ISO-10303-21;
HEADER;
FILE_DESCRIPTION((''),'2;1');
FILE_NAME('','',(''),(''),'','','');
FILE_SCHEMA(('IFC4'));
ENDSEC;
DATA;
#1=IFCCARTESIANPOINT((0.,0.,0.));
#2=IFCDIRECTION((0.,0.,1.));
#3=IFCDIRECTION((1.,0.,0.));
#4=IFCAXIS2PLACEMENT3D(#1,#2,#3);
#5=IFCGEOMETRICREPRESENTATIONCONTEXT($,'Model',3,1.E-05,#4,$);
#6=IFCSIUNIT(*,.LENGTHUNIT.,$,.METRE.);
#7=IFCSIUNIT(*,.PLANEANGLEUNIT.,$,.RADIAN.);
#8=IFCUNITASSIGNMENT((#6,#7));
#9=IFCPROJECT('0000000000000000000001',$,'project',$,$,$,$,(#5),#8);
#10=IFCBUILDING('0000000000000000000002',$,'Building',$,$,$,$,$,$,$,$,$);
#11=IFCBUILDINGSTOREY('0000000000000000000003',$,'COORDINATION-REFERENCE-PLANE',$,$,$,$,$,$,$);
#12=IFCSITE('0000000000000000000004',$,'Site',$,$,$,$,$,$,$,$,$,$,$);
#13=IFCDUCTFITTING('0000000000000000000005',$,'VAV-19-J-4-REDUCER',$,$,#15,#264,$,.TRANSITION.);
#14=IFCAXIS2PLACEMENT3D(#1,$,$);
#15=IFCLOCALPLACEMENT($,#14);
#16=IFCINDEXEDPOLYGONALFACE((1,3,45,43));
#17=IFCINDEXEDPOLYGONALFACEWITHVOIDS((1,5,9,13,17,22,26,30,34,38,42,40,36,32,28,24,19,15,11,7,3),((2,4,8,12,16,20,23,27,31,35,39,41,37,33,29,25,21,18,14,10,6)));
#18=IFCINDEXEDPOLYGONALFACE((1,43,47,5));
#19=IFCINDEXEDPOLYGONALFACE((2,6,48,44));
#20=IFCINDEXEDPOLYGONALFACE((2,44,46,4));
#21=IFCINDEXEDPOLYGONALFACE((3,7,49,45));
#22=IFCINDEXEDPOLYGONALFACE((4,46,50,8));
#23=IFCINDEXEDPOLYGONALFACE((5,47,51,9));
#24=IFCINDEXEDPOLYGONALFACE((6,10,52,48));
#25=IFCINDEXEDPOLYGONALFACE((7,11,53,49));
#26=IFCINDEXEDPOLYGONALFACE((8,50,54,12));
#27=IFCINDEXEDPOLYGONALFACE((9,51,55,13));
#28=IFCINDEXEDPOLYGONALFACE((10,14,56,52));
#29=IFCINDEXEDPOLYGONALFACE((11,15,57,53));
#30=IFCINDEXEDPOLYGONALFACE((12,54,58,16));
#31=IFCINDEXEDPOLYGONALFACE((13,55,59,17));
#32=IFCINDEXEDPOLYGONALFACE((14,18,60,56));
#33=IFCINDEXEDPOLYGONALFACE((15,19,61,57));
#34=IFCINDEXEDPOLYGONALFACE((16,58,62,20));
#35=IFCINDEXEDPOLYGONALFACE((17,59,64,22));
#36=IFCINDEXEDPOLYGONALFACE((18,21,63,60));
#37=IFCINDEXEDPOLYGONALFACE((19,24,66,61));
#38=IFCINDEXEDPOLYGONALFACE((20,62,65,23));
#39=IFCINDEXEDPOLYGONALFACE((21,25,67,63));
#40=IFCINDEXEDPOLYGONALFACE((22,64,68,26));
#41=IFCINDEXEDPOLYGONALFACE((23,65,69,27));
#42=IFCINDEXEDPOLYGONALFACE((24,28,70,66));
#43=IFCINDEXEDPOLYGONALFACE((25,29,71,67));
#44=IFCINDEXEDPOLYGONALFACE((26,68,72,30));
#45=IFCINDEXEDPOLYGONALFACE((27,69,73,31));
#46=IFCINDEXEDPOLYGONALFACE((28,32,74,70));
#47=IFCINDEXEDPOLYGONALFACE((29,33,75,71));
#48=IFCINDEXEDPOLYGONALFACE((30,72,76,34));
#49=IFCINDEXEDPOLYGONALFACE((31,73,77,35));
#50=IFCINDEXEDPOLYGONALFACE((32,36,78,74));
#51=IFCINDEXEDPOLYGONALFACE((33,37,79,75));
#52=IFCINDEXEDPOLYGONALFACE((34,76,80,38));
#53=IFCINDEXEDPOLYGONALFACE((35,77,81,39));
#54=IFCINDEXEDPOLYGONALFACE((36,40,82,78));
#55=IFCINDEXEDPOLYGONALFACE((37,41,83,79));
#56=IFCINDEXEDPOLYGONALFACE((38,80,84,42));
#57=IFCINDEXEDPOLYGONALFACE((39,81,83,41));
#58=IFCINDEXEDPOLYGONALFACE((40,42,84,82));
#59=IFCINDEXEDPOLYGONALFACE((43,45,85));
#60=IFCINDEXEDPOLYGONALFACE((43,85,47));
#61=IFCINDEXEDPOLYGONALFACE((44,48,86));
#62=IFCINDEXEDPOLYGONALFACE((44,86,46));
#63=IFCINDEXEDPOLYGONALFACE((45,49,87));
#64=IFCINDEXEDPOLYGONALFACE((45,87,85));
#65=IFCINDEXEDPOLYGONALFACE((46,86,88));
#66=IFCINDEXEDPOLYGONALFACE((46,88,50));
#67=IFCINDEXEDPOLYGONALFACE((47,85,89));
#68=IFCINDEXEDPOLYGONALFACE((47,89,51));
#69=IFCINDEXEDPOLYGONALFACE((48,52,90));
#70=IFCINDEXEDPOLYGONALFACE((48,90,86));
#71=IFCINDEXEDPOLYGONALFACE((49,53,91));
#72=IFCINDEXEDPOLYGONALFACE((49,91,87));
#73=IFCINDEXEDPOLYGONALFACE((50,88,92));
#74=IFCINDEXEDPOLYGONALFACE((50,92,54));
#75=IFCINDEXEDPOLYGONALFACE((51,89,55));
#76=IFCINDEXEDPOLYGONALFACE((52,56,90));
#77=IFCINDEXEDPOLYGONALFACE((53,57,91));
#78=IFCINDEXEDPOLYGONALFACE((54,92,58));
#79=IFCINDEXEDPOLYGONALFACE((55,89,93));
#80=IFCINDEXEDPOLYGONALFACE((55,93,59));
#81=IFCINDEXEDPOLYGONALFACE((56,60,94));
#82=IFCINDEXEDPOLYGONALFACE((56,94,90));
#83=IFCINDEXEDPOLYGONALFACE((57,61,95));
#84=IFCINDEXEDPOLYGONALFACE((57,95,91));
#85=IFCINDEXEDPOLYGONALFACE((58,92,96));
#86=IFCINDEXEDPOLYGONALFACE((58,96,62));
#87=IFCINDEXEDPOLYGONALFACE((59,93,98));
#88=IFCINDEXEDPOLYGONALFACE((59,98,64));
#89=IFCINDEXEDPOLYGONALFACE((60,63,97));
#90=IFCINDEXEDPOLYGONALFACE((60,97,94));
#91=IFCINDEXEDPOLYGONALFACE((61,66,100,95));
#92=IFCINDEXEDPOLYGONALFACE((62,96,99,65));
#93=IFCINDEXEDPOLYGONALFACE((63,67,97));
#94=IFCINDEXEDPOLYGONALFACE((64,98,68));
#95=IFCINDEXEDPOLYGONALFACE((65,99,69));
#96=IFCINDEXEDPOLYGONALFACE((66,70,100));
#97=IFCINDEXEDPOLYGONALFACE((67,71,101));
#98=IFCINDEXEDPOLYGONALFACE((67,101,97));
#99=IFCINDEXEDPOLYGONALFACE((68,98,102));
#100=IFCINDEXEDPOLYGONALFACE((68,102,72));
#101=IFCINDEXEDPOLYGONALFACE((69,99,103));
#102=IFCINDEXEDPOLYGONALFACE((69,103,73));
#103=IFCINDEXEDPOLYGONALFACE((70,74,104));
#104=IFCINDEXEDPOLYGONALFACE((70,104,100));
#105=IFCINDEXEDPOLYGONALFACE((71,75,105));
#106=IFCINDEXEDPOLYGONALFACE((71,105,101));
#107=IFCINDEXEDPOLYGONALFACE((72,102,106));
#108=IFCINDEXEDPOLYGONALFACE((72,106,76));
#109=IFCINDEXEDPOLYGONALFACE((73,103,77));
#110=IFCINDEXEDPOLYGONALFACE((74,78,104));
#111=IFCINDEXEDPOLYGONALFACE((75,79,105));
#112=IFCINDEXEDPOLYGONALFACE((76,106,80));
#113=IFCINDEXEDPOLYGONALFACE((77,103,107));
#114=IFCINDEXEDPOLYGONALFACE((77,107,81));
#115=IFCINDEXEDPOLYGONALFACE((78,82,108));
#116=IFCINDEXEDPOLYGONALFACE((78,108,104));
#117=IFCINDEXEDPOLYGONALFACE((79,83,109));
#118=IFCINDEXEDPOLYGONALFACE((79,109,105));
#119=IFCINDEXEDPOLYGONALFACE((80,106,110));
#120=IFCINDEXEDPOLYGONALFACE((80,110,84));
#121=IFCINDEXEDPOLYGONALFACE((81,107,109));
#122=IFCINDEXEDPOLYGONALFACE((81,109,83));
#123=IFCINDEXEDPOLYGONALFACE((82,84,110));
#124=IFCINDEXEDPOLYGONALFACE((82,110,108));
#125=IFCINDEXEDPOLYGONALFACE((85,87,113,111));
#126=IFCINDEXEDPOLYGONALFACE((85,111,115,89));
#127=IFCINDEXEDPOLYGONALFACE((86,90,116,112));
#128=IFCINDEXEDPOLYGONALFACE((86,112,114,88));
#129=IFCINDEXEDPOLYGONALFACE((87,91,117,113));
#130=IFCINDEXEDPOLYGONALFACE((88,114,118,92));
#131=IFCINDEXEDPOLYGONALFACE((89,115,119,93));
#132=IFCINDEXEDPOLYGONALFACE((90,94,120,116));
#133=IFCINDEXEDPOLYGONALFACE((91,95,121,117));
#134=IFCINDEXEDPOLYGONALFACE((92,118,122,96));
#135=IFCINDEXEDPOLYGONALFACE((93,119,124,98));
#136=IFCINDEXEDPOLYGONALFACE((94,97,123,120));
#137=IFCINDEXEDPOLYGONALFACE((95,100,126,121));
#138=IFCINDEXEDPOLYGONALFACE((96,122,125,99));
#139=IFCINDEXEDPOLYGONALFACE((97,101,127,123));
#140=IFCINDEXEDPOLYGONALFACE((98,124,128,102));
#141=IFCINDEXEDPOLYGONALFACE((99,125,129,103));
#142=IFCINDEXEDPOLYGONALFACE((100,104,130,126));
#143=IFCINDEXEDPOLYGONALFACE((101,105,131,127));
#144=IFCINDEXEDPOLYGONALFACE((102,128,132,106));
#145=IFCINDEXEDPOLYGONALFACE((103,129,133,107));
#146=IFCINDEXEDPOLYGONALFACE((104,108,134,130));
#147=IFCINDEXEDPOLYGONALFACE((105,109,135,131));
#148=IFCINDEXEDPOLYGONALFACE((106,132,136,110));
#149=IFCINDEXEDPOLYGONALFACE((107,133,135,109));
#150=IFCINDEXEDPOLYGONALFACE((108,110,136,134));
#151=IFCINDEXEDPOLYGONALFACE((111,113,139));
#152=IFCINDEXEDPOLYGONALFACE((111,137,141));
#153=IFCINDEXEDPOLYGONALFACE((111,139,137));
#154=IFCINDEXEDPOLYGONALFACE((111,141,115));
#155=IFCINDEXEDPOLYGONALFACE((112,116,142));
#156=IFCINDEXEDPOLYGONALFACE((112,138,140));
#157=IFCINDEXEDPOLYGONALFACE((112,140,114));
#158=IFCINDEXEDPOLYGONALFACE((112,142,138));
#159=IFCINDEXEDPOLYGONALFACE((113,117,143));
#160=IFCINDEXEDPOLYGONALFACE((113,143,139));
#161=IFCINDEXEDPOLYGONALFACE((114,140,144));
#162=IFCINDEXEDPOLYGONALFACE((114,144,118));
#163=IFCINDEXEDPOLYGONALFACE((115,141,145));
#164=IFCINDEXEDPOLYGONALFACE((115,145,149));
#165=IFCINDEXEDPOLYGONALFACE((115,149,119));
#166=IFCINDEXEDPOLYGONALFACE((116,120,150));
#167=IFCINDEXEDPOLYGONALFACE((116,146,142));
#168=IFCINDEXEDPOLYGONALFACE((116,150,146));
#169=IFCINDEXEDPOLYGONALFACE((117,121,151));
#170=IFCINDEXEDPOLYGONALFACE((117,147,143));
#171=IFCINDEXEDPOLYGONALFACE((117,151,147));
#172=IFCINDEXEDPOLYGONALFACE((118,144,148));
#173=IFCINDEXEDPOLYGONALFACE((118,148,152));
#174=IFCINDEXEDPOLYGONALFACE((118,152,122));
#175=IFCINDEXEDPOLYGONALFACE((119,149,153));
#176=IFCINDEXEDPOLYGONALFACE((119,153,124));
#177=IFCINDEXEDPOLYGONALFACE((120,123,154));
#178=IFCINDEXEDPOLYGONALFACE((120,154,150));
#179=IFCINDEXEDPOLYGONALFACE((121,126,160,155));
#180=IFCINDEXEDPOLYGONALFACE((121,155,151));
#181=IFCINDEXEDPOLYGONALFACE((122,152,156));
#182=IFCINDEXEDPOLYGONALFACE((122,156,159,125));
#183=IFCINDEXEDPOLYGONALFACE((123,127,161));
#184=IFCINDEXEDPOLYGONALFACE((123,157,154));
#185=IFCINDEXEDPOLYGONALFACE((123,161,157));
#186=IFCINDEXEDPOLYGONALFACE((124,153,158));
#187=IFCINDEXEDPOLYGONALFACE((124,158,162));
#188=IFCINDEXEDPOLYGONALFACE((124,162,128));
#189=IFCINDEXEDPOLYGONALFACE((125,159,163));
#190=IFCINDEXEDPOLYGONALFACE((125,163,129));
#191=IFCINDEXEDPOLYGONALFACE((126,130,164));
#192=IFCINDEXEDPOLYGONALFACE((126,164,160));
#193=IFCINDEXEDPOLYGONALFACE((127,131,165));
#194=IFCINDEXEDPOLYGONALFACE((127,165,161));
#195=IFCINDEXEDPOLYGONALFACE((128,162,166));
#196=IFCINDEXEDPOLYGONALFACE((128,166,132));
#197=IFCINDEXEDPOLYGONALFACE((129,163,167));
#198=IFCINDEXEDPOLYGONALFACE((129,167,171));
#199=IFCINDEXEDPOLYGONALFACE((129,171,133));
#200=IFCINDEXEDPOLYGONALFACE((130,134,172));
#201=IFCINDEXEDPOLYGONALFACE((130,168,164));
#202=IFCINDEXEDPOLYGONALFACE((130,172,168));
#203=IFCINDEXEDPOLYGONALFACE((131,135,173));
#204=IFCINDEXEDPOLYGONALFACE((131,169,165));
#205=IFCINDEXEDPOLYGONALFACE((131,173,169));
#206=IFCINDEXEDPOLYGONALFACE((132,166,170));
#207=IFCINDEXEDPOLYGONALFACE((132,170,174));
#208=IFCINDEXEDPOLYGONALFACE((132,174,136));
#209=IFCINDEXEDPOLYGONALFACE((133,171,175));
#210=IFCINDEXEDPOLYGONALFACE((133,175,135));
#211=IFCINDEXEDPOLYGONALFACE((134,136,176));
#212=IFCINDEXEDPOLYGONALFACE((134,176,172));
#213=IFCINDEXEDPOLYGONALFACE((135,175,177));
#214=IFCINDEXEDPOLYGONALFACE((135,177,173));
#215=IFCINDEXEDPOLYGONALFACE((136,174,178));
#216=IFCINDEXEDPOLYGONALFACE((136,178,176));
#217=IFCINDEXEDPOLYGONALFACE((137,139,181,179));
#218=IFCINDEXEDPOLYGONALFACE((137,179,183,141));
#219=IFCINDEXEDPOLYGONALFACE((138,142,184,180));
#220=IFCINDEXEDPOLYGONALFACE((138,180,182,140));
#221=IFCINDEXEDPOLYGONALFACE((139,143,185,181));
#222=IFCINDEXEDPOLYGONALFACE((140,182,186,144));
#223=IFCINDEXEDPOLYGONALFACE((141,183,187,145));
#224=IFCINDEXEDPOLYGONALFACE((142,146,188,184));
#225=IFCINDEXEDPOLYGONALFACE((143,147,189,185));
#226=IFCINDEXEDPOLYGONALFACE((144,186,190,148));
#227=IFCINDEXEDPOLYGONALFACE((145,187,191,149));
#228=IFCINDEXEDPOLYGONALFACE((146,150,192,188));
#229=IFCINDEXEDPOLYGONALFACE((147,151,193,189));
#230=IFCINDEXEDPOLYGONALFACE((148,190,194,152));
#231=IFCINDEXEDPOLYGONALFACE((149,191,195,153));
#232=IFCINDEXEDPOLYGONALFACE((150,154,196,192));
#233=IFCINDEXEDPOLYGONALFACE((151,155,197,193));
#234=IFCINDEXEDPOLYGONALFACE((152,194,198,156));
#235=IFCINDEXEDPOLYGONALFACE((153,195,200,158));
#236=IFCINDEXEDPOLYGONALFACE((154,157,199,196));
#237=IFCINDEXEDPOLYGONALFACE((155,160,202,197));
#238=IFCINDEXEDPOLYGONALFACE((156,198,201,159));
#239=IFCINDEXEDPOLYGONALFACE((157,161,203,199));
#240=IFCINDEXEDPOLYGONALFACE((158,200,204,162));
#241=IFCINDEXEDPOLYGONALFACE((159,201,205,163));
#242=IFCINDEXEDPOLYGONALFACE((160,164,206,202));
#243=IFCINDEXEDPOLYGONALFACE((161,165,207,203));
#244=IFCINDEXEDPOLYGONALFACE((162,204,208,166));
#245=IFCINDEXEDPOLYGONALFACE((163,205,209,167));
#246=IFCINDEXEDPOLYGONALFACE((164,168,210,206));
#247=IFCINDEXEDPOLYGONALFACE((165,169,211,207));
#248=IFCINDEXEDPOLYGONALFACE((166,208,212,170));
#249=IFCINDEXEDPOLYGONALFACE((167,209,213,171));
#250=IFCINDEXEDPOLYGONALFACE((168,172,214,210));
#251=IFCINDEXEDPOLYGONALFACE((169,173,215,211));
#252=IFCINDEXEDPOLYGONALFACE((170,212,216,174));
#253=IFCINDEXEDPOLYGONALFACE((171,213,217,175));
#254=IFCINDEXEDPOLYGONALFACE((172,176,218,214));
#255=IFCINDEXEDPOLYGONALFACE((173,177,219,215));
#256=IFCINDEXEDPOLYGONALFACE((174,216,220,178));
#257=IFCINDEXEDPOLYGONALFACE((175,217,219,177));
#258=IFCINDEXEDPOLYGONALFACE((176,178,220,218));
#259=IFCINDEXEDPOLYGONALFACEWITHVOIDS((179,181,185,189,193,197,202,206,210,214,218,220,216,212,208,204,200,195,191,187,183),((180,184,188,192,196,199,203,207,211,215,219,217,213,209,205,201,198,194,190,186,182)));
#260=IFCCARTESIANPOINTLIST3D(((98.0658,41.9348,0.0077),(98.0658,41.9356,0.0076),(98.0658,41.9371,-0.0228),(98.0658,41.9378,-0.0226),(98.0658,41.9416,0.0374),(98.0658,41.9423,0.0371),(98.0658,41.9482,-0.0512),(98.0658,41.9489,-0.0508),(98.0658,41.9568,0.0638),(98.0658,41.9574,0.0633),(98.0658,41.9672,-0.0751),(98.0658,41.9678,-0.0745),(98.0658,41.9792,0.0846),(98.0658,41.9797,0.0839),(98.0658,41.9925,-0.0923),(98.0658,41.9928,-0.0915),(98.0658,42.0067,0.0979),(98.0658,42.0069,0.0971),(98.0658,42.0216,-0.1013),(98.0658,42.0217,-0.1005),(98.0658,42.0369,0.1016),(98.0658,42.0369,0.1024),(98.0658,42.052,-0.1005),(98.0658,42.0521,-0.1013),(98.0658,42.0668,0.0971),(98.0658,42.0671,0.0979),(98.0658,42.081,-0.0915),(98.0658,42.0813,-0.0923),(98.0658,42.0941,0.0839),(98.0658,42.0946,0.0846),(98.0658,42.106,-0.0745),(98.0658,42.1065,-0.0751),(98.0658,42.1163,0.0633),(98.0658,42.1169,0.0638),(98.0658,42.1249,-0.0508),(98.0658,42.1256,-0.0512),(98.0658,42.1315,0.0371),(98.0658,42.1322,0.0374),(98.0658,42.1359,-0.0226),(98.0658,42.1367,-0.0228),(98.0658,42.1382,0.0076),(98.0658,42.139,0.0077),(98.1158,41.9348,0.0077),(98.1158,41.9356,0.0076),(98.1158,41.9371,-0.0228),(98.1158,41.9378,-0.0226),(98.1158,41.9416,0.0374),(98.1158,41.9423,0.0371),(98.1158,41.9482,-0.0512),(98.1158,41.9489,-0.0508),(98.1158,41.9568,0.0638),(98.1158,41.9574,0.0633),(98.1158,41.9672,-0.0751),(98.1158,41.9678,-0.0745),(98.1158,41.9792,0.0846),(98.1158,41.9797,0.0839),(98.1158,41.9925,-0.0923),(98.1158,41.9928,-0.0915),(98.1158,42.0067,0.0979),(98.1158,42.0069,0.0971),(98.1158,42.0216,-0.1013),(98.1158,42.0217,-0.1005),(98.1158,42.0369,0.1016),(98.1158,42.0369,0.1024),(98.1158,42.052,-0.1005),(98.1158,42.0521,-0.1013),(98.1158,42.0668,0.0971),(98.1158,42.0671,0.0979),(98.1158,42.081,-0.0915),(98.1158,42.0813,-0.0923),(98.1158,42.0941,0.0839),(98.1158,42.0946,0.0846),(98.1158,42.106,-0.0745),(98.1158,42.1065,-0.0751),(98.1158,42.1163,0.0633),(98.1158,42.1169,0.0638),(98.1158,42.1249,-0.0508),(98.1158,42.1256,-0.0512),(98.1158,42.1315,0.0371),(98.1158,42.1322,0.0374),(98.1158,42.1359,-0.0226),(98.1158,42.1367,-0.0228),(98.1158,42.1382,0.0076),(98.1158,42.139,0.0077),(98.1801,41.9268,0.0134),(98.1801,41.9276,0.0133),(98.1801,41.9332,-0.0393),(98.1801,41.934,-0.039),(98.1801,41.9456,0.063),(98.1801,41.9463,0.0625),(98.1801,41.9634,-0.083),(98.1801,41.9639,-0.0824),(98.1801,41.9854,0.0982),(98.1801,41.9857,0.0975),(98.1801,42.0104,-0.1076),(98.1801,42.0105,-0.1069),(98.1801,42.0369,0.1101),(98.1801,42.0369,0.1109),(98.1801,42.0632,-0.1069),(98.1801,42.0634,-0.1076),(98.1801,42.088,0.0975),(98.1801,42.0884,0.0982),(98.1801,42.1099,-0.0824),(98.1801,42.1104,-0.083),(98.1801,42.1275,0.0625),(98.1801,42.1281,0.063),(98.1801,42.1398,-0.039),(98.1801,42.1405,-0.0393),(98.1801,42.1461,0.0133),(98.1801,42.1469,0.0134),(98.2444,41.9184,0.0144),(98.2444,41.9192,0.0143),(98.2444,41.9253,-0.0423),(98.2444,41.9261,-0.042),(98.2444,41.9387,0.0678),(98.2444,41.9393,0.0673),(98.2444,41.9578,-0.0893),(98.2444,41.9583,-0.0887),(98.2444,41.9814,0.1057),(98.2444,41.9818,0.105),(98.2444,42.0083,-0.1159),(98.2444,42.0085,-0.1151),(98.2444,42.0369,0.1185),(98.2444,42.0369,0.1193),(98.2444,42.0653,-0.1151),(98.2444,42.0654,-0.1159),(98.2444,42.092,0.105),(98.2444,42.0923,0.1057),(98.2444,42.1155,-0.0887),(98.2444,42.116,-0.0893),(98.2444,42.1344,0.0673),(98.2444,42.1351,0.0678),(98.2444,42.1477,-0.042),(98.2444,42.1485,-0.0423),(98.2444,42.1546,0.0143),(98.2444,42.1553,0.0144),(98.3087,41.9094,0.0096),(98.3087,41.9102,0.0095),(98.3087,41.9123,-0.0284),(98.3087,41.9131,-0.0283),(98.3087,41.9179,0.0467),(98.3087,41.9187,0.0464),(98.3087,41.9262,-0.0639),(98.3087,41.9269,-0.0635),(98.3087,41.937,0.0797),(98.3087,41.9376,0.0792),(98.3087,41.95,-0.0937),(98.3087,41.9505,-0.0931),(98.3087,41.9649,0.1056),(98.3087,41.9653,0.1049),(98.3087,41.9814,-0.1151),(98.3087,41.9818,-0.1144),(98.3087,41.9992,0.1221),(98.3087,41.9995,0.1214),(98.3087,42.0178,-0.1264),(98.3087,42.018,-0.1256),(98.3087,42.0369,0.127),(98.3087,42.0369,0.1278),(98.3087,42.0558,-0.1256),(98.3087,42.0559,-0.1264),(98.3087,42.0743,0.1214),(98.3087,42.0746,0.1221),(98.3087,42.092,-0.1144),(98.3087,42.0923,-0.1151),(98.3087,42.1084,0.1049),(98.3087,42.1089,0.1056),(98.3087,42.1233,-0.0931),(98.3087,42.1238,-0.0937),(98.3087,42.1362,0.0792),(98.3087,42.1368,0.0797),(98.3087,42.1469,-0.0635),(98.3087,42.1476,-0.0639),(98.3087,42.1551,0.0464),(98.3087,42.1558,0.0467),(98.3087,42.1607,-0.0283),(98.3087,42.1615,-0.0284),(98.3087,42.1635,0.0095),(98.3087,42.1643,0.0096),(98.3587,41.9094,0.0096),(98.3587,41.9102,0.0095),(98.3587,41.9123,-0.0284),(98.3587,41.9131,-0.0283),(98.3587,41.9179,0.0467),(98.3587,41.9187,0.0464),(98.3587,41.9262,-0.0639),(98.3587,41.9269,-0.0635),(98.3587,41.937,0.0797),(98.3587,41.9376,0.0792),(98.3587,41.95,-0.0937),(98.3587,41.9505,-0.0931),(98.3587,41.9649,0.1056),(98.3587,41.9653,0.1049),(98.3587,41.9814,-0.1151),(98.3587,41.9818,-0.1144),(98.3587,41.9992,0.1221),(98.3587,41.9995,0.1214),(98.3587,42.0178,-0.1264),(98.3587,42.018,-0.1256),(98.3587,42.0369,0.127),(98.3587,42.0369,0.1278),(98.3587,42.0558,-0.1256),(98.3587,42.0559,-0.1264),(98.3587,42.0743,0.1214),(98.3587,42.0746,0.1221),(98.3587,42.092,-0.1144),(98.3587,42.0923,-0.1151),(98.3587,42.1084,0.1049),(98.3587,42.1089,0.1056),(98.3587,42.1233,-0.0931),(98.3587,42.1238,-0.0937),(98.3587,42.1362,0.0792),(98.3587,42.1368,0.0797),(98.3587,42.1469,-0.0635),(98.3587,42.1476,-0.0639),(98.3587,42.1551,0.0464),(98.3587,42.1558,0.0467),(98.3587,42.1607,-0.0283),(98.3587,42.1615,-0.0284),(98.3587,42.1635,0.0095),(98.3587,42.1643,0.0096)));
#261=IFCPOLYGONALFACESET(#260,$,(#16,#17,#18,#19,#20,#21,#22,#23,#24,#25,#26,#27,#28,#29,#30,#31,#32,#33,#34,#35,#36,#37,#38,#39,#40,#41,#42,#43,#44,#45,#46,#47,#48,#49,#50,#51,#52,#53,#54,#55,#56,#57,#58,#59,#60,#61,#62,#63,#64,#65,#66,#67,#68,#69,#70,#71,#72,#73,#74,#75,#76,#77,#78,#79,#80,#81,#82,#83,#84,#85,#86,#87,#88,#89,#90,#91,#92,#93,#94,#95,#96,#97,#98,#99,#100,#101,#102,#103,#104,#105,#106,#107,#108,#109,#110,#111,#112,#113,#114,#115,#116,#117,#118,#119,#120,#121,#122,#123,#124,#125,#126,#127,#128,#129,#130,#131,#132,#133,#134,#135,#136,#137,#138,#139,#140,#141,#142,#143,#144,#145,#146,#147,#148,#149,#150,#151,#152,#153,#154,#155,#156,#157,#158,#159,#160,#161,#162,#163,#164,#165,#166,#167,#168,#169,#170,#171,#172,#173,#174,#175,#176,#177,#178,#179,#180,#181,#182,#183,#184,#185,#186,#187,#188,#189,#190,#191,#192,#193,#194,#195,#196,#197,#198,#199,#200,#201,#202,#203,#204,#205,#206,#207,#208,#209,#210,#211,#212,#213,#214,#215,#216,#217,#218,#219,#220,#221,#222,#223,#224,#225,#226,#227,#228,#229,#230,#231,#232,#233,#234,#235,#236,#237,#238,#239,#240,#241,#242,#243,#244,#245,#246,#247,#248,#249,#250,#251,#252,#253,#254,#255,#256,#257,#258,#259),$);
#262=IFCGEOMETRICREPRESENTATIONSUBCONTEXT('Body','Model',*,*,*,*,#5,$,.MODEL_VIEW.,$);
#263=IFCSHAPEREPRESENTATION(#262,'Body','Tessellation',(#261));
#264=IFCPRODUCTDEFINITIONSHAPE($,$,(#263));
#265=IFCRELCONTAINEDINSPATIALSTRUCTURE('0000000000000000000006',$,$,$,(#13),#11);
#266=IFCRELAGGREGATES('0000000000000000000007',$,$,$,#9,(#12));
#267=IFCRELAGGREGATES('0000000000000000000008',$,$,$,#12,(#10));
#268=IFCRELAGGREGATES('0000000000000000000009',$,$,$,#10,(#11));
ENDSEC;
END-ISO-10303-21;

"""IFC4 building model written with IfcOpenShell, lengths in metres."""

from ifc_helpers import new_model, entity, si_unit, frame, origin_with_axes, place, context, subcontext, project, spatial, element, save


model = new_model("IFC4")

# Units and contexts
model_context = context("Model", 3, precision=1e-05, world=origin_with_axes())
body_context_1 = subcontext(model_context, "Body", "Model", "MODEL_VIEW")
ifc_project = project(units=[si_unit("LENGTHUNIT", "METRE"), si_unit("PLANEANGLEUNIT", "RADIAN")], contexts=[model_context])

# Site, building, storey
site = spatial("IfcSite", under=ifc_project, Name="Site")
building = spatial("IfcBuilding", under=site, Name="Building")
storey = spatial("IfcBuildingStorey", under=building, Name="COORDINATION-REFERENCE-PLANE")

# Duct fitting
for number, where, z_axis, x_axis, name in (
    (1, (98.3587, 42.0369, 0.0), (0.0, -1.0, 0.0), (0.0, 0.0, 1.0), "VAV-19-J-4-REDUCER"),
):
    element("IfcDuctFitting", number, at=place(None, frame(where, z_axis=z_axis, x_axis=x_axis)), inside=storey, Name=name, PredefinedType="TRANSITION", context=body_context_1, shape_type="SweptSolid", body=[
        entity("IfcRevolvedAreaSolid", entity("IfcArbitraryClosedProfileDef", "AREA", None, entity("IfcPolyline", [entity("IfcCartesianPoint", [0.1278, 0.0]), entity("IfcCartesianPoint", [0.1278, 0.05]), entity("IfcCartesianPoint", [0.1024, 0.2429]), entity("IfcCartesianPoint", [0.1024, 0.2929]), entity("IfcCartesianPoint", [0.1016, 0.2929]), entity("IfcCartesianPoint", [0.1016, 0.2429]), entity("IfcCartesianPoint", [0.127, 0.05]), entity("IfcCartesianPoint", [0.127, 0.0]), entity("IfcCartesianPoint", [0.1278, 0.0])])), entity("IfcAxis2Placement3D", entity("IfcCartesianPoint", [0.0, 0.0, 0.0])), entity("IfcAxis1Placement", entity("IfcCartesianPoint", [0.0, 0.0, 0.0]), entity("IfcDirection", [0.0, 1.0, 0.0])), 6.283185),
    ])

save(model, "model.ifc")
